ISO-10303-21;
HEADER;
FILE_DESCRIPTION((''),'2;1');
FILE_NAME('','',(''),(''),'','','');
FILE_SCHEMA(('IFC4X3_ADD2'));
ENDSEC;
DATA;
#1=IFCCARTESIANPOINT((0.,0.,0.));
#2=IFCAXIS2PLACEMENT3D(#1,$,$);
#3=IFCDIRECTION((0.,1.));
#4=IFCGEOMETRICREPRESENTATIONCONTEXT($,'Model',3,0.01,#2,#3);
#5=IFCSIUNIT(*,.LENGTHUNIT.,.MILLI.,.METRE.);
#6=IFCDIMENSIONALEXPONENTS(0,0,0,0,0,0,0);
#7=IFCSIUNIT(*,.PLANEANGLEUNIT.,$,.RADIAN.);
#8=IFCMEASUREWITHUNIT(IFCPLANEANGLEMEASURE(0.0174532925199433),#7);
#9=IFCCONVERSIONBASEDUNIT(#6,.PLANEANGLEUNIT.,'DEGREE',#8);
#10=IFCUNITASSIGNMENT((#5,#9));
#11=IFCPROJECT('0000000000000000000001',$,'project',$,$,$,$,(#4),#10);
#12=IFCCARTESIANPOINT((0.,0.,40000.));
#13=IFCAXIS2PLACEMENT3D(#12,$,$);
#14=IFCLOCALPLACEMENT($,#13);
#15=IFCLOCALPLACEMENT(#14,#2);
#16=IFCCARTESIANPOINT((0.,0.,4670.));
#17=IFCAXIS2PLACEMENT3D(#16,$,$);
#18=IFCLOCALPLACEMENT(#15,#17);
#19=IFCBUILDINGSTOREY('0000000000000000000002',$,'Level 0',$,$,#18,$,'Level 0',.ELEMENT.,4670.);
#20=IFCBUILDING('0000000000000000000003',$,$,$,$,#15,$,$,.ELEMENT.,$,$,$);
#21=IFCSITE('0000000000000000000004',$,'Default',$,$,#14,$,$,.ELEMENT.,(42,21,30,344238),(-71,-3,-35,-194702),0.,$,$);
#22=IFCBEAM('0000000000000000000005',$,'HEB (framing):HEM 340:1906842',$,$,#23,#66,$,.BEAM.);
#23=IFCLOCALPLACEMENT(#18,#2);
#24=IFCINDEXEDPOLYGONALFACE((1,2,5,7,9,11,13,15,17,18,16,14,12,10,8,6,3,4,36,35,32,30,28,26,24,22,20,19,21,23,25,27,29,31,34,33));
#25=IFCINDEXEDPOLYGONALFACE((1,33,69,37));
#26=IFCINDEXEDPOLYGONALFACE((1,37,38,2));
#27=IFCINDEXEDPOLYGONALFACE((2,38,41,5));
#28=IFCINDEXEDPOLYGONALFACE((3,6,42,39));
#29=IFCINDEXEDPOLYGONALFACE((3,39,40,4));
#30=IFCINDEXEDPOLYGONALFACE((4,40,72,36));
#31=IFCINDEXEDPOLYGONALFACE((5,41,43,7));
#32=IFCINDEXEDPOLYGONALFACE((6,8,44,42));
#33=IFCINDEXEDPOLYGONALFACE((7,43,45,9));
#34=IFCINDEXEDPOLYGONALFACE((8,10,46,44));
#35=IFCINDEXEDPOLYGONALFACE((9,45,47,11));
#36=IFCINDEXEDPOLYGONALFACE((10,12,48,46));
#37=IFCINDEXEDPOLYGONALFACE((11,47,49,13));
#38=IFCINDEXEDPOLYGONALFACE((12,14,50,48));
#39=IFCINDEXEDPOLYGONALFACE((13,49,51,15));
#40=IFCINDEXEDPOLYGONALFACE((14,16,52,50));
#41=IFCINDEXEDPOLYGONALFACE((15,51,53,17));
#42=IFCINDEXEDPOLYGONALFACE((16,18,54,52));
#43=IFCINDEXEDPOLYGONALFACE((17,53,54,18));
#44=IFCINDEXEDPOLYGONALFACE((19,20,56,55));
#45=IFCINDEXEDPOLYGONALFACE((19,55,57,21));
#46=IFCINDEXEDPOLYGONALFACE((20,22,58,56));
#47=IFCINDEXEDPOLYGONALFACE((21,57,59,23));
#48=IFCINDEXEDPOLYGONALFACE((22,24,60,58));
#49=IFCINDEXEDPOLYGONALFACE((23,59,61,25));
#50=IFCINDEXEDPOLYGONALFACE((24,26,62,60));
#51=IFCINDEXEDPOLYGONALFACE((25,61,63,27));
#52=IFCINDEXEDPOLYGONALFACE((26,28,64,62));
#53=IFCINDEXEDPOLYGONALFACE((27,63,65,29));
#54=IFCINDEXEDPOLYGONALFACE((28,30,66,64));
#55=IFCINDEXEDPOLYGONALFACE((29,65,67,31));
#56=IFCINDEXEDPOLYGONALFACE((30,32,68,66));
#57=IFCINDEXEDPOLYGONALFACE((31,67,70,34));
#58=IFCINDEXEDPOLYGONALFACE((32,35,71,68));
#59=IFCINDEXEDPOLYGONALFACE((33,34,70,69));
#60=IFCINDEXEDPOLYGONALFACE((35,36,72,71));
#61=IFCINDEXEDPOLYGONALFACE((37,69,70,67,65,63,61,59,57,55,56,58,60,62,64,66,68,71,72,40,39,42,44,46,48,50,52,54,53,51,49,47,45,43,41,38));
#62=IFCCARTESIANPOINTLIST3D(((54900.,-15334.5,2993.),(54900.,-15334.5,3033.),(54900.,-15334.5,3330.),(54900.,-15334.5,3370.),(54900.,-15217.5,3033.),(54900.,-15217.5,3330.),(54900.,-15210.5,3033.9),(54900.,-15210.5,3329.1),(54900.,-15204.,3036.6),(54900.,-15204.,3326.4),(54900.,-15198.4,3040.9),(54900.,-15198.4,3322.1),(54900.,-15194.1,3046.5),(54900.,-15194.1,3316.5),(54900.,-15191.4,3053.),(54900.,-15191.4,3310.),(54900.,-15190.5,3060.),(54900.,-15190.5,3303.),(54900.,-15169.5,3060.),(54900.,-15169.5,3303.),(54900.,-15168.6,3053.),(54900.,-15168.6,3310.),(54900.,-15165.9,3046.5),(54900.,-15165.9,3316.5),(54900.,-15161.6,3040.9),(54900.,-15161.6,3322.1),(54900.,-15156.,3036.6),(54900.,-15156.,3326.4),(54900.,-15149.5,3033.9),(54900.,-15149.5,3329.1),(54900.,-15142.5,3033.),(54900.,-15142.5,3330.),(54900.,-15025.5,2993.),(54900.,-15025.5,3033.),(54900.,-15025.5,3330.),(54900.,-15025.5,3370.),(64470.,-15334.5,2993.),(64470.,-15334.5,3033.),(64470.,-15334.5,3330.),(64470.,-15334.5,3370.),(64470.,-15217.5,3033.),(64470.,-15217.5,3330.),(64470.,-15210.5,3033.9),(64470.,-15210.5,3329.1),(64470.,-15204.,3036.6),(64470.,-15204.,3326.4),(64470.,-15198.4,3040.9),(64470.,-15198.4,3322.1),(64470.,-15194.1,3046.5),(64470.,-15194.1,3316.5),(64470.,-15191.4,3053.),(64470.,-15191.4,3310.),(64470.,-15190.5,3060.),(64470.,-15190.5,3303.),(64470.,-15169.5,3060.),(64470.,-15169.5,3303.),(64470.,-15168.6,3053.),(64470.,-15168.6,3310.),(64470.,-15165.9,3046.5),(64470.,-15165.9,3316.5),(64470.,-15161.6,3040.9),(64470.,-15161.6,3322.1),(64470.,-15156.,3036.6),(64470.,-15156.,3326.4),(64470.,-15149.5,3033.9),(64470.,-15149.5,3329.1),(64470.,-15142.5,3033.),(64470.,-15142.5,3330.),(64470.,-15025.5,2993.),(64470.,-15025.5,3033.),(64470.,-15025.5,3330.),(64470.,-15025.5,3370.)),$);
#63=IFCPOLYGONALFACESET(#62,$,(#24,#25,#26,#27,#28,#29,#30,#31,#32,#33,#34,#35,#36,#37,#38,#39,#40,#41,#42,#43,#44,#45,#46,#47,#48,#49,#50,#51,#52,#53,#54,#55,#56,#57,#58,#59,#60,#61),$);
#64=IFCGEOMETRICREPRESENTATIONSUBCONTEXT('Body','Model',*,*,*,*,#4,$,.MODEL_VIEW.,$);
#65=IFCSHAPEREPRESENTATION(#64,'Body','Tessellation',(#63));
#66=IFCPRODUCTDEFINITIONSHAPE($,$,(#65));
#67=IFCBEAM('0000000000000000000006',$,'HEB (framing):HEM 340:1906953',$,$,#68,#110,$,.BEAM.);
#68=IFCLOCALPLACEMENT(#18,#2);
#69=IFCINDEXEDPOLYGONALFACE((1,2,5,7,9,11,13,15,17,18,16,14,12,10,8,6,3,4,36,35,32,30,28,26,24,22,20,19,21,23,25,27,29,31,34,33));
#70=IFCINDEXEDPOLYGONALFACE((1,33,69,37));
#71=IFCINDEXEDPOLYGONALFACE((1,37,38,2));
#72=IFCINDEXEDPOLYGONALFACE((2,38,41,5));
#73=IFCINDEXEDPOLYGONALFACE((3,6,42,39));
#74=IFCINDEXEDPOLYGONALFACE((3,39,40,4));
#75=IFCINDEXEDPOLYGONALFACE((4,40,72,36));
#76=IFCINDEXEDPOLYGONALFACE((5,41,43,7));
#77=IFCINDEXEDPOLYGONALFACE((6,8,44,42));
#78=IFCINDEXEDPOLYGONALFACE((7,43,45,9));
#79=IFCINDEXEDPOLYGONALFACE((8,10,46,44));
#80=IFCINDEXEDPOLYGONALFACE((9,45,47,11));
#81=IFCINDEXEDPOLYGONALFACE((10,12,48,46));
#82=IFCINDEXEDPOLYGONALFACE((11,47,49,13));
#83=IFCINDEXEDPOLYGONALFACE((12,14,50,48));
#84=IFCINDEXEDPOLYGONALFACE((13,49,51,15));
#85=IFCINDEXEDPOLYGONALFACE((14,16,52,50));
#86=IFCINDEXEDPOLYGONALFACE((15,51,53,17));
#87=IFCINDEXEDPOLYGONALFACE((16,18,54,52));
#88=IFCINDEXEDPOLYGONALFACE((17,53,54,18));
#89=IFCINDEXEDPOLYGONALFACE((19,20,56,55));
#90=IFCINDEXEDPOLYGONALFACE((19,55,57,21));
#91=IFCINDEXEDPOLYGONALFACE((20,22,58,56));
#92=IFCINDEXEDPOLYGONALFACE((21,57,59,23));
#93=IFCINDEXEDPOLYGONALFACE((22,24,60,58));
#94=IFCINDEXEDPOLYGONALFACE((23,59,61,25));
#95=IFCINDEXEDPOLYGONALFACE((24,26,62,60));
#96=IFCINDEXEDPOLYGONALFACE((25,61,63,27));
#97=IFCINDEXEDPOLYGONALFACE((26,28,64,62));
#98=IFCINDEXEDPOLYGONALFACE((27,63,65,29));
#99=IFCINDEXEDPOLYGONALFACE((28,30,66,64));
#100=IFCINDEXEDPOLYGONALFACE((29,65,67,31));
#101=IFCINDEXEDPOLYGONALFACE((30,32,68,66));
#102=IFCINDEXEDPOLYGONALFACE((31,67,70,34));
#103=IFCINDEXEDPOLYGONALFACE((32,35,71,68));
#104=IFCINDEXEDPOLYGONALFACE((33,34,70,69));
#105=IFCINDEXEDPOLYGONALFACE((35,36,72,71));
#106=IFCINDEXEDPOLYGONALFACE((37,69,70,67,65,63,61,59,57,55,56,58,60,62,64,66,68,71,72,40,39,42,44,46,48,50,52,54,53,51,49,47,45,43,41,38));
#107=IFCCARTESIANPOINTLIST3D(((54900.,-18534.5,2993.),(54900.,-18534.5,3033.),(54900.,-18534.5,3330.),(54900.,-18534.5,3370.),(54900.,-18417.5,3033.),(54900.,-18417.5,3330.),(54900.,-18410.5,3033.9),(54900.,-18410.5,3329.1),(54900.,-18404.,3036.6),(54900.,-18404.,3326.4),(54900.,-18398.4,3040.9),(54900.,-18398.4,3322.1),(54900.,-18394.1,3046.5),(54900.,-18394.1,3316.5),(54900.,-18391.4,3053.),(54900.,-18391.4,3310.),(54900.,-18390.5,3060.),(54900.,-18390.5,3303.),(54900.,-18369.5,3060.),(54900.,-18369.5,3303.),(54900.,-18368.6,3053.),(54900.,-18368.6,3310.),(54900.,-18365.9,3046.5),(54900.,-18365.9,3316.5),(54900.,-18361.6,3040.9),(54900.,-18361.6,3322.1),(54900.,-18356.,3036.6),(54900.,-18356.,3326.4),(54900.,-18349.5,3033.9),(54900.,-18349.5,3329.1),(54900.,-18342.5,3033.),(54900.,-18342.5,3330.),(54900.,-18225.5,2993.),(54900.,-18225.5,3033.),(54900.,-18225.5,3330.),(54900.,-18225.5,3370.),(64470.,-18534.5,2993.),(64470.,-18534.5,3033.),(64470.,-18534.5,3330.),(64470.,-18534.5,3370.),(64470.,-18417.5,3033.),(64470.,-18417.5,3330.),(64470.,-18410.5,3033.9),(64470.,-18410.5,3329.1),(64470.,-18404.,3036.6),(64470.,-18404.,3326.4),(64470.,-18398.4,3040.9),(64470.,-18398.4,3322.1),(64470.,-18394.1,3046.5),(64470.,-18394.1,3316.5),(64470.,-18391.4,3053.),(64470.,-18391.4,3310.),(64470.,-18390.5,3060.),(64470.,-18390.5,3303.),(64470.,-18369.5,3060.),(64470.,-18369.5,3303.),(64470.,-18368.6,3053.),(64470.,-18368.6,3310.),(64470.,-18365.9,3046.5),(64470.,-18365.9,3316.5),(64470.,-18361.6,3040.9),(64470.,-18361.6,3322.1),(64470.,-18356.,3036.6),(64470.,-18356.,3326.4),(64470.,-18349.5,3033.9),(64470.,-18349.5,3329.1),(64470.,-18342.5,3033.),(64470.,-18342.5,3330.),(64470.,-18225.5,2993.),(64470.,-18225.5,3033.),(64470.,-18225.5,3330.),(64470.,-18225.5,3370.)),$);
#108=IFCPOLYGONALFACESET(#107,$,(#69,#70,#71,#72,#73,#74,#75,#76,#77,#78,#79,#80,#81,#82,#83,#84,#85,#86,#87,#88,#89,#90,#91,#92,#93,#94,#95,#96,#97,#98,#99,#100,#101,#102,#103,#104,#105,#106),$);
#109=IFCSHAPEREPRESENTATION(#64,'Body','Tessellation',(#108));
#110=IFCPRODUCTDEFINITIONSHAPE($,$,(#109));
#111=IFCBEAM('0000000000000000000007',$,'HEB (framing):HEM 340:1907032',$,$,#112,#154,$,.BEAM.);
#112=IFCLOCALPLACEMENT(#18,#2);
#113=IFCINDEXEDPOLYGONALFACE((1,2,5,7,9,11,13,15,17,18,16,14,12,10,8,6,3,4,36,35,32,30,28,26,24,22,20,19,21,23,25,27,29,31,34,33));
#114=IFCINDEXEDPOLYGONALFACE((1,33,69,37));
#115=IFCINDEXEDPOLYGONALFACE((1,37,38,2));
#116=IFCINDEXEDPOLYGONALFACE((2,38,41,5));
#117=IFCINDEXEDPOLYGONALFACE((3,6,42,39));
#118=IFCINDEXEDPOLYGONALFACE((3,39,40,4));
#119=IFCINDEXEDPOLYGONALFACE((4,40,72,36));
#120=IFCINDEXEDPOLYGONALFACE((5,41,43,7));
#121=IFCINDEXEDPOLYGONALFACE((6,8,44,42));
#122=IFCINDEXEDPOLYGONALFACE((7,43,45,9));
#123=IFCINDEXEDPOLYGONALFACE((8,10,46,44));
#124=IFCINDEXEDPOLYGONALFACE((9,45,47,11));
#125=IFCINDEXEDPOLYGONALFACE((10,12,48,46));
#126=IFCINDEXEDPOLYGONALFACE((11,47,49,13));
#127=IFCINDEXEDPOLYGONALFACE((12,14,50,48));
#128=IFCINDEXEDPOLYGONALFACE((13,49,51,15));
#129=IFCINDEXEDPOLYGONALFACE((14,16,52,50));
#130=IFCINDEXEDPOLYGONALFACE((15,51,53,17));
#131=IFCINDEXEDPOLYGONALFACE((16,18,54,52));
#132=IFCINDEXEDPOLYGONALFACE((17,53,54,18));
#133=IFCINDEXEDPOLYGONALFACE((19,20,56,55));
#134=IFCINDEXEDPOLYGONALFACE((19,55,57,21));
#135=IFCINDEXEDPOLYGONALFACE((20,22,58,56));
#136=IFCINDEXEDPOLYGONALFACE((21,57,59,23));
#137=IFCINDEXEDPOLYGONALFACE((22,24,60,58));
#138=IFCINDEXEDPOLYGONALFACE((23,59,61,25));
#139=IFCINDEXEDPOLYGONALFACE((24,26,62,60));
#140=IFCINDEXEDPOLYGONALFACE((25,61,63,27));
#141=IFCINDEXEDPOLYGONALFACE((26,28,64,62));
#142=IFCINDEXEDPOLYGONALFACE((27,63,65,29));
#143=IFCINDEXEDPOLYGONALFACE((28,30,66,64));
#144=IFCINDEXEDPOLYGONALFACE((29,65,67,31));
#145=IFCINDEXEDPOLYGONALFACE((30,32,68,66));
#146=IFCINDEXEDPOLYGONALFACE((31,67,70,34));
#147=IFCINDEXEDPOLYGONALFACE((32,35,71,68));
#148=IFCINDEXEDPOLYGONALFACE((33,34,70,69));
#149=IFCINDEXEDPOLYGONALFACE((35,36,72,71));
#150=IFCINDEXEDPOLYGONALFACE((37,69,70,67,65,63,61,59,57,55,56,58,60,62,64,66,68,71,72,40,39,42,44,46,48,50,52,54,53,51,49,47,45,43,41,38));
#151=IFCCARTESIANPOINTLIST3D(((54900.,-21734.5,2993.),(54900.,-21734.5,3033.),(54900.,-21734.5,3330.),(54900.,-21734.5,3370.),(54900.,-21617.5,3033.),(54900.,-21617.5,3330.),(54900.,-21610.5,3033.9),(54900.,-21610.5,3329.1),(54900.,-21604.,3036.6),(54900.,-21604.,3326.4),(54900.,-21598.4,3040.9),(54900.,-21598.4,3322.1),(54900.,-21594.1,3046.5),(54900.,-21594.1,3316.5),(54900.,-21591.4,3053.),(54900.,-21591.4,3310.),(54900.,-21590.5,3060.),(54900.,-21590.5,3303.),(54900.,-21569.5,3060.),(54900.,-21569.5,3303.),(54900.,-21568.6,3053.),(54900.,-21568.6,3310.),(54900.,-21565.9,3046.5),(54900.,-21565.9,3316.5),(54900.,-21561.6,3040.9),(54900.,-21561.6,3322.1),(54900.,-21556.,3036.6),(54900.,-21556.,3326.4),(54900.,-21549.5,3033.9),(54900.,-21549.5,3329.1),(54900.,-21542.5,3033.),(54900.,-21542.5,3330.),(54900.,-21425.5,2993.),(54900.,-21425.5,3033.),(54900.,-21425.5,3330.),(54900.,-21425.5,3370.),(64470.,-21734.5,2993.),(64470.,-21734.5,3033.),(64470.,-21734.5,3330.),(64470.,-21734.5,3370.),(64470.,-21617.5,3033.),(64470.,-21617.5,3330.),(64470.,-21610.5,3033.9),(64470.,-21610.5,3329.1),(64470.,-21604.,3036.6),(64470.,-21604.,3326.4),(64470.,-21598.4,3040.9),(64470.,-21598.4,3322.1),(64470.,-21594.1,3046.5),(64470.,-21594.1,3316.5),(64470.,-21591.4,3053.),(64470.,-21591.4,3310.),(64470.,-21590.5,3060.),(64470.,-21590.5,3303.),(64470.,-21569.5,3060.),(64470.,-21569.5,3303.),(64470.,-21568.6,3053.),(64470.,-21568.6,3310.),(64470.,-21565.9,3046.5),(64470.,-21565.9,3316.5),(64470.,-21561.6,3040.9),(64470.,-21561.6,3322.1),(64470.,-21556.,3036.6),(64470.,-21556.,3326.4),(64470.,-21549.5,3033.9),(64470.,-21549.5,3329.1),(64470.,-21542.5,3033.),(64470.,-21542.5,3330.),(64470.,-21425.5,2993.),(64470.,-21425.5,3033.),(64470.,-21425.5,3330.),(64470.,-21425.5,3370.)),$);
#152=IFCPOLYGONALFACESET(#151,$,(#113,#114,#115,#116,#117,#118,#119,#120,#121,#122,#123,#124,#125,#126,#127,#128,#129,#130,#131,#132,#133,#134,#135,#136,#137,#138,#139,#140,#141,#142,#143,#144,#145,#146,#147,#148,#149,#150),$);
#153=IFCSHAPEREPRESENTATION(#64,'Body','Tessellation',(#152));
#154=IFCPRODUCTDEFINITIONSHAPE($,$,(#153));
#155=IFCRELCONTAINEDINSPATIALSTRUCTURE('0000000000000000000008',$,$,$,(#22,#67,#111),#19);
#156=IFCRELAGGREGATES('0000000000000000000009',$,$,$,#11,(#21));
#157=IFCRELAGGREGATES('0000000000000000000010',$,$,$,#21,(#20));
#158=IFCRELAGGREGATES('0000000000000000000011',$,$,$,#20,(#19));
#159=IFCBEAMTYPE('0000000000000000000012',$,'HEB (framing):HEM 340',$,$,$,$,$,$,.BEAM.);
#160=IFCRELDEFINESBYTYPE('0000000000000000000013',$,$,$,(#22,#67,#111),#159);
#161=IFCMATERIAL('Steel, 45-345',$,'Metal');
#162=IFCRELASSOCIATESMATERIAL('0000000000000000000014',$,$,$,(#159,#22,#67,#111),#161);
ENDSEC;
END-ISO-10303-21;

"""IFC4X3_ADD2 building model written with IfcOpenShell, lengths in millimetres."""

from ifc_helpers import new_model, entity, si_unit, converted_unit, direction, frame, frame_2d, origin, place, context, subcontext, project, spatial, polyline, circle_curve, parameter, trimmed, segment, composite_curve, outline, extrude, source, transform, mapped, material, material_profile, profile_set, profile_usage, type_object, type_shapes, element, save


model = new_model("IFC4X3_ADD2")

# Units and contexts
model_context = context("Model", 3, precision=0.01, world=origin(), true_north=direction((0.0, 1.0)))
body_context = subcontext(model_context, "Body", "Model", "MODEL_VIEW")
ifc_project = project(units=[si_unit("LENGTHUNIT", "METRE", prefix="MILLI"), converted_unit("PLANEANGLEUNIT", "DEGREE", entity("IfcPlaneAngleMeasure", 0.0174532925199433), si_unit("PLANEANGLEUNIT", "RADIAN"), dimensions=[0, 0, 0, 0, 0, 0, 0])], contexts=[model_context])

# Site, building, storey
site_placement = place(None, frame((0.0, 0.0, 40000.0)))
site = spatial("IfcSite", under=ifc_project, at=site_placement, Name="Default", CompositionType="ELEMENT", RefLatitude=(42, 21, 30, 344238), RefLongitude=(-71, -3, -35, -194702), RefElevation=0.0)
building_placement = place(site_placement, origin())
building = spatial("IfcBuilding", under=site, at=building_placement, CompositionType="ELEMENT")
storey_placement = place(building_placement, frame((0.0, 0.0, 4670.0)))
storey = spatial("IfcBuildingStorey", under=building, at=storey_placement, Name="Level 0", LongName="Level 0", CompositionType="ELEMENT", Elevation=4670.0)

# Shared definitions
ifc_material_1 = material(Name="Steel, 45-345", Category="Metal")

# Beams
ifc_material_profile_1 = material_profile(ifc_material_1, outline(composite_curve([segment(polyline([(-154.5, -148.5), (-154.5, -188.5)]), True, "CONTINUOUS"), segment(polyline([(-154.5, -188.5), (154.5, -188.5)]), True, "CONTINUOUS"), segment(polyline([(154.5, -188.5), (154.5, -148.5)]), True, "CONTINUOUS"), segment(polyline([(154.5, -148.5), (37.5, -148.5)]), True, "CONTINUOUS"), segment(trimmed(circle_curve(frame_2d((37.5, -121.5), x_axis=(1.0, 0.0)), 27.0), [parameter(180.0)], [parameter(270.0)], True, "PARAMETER"), False, "CONTINUOUS"), segment(polyline([(10.5, -121.5), (10.5, 121.5)]), True, "CONTINUOUS"), segment(trimmed(circle_curve(frame_2d((37.5, 121.5), x_axis=(1.0, 0.0)), 27.0), [parameter(90.0)], [parameter(180.0)], True, "PARAMETER"), False, "CONTINUOUS"), segment(polyline([(37.5, 148.5), (154.5, 148.5)]), True, "CONTINUOUS"), segment(polyline([(154.5, 148.5), (154.5, 188.5)]), True, "CONTINUOUS"), segment(polyline([(154.5, 188.5), (-154.5, 188.5)]), True, "CONTINUOUS"), segment(polyline([(-154.5, 188.5), (-154.5, 148.5)]), True, "CONTINUOUS"), segment(polyline([(-154.5, 148.5), (-37.5, 148.5)]), True, "CONTINUOUS"), segment(trimmed(circle_curve(frame_2d((-37.5, 121.5), x_axis=(1.0, 0.0)), 27.0), [parameter(360.0)], [parameter(90.0)], True, "PARAMETER"), False, "CONTINUOUS"), segment(polyline([(-10.5, 121.5), (-10.5, -121.5)]), True, "CONTINUOUS"), segment(trimmed(circle_curve(frame_2d((-37.5, -121.5), x_axis=(1.0, 0.0)), 27.0), [parameter(270.0)], [parameter(0.0)], True, "PARAMETER"), False, "CONTINUOUS"), segment(polyline([(-37.5, -148.5), (-154.5, -148.5)]), True, "CONTINUOUS")], self_intersect=False)), Name="HEM 340")
ifc_profile_set_1 = profile_set([ifc_material_profile_1], Name="HEM 340")
ifc_profile_usage_1 = profile_usage(ifc_profile_set_1, cardinal=8)
beam_type_1 = type_object("IfcBeamType", Name="HEB (framing):HEM 340", PredefinedType="BEAM", material=ifc_profile_set_1)
shared_shape_1 = source(origin(), body_context, "Body", "SweptSolid", [
    extrude(outline(composite_curve([segment(polyline([(-154.5, -148.5), (-154.5, -188.5)]), True, "CONTINUOUS"), segment(polyline([(-154.5, -188.5), (154.5, -188.5)]), True, "CONTINUOUS"), segment(polyline([(154.5, -188.5), (154.5, -148.5)]), True, "CONTINUOUS"), segment(polyline([(154.5, -148.5), (37.5, -148.5)]), True, "CONTINUOUS"), segment(trimmed(circle_curve(frame_2d((37.5, -121.5), x_axis=(1.0, 0.0)), 27.0), [parameter(180.0)], [parameter(270.0)], True, "PARAMETER"), False, "CONTINUOUS"), segment(polyline([(10.5, -121.5), (10.5, 121.5)]), True, "CONTINUOUS"), segment(trimmed(circle_curve(frame_2d((37.5, 121.5), x_axis=(1.0, 0.0)), 27.0), [parameter(90.0)], [parameter(180.0)], True, "PARAMETER"), False, "CONTINUOUS"), segment(polyline([(37.5, 148.5), (154.5, 148.5)]), True, "CONTINUOUS"), segment(polyline([(154.5, 148.5), (154.5, 188.5)]), True, "CONTINUOUS"), segment(polyline([(154.5, 188.5), (-154.5, 188.5)]), True, "CONTINUOUS"), segment(polyline([(-154.5, 188.5), (-154.5, 148.5)]), True, "CONTINUOUS"), segment(polyline([(-154.5, 148.5), (-37.5, 148.5)]), True, "CONTINUOUS"), segment(trimmed(circle_curve(frame_2d((-37.5, 121.5), x_axis=(1.0, 0.0)), 27.0), [parameter(360.0)], [parameter(90.0)], True, "PARAMETER"), False, "CONTINUOUS"), segment(polyline([(-10.5, 121.5), (-10.5, -121.5)]), True, "CONTINUOUS"), segment(trimmed(circle_curve(frame_2d((-37.5, -121.5), x_axis=(1.0, 0.0)), 27.0), [parameter(270.0)], [parameter(0.0)], True, "PARAMETER"), False, "CONTINUOUS"), segment(polyline([(-37.5, -148.5), (-154.5, -148.5)]), True, "CONTINUOUS")], self_intersect=False)), frame((-4742.5, 0.0, 0.0), z_axis=(-1.0, 0.0, 0.0), x_axis=(0.0, -1.0, 0.0)), (0.0, 0.0, -1.0), 9570.0),
])
type_shapes(beam_type_1, [shared_shape_1])
for number, where, name in (
    (1, (59642.5, -15180.0, 3181.5), "HEB (framing):HEM 340:1906842"),
    (2, (59642.5, -18380.0, 3181.5), "HEB (framing):HEM 340:1906953"),
    (3, (59642.5, -21580.0, 3181.5), "HEB (framing):HEM 340:1907032"),
):
    element("IfcBeam", number, at=place(storey_placement, frame(where)), inside=storey, type_object=beam_type_1, material=ifc_profile_usage_1, Name=name, PredefinedType="BEAM", context=body_context, shape_type="MappedRepresentation", body=[
        mapped(shared_shape_1, transform((0.0, 0.0, 0.0), scale=1.0)),
    ])

save(model, "model.ifc")
